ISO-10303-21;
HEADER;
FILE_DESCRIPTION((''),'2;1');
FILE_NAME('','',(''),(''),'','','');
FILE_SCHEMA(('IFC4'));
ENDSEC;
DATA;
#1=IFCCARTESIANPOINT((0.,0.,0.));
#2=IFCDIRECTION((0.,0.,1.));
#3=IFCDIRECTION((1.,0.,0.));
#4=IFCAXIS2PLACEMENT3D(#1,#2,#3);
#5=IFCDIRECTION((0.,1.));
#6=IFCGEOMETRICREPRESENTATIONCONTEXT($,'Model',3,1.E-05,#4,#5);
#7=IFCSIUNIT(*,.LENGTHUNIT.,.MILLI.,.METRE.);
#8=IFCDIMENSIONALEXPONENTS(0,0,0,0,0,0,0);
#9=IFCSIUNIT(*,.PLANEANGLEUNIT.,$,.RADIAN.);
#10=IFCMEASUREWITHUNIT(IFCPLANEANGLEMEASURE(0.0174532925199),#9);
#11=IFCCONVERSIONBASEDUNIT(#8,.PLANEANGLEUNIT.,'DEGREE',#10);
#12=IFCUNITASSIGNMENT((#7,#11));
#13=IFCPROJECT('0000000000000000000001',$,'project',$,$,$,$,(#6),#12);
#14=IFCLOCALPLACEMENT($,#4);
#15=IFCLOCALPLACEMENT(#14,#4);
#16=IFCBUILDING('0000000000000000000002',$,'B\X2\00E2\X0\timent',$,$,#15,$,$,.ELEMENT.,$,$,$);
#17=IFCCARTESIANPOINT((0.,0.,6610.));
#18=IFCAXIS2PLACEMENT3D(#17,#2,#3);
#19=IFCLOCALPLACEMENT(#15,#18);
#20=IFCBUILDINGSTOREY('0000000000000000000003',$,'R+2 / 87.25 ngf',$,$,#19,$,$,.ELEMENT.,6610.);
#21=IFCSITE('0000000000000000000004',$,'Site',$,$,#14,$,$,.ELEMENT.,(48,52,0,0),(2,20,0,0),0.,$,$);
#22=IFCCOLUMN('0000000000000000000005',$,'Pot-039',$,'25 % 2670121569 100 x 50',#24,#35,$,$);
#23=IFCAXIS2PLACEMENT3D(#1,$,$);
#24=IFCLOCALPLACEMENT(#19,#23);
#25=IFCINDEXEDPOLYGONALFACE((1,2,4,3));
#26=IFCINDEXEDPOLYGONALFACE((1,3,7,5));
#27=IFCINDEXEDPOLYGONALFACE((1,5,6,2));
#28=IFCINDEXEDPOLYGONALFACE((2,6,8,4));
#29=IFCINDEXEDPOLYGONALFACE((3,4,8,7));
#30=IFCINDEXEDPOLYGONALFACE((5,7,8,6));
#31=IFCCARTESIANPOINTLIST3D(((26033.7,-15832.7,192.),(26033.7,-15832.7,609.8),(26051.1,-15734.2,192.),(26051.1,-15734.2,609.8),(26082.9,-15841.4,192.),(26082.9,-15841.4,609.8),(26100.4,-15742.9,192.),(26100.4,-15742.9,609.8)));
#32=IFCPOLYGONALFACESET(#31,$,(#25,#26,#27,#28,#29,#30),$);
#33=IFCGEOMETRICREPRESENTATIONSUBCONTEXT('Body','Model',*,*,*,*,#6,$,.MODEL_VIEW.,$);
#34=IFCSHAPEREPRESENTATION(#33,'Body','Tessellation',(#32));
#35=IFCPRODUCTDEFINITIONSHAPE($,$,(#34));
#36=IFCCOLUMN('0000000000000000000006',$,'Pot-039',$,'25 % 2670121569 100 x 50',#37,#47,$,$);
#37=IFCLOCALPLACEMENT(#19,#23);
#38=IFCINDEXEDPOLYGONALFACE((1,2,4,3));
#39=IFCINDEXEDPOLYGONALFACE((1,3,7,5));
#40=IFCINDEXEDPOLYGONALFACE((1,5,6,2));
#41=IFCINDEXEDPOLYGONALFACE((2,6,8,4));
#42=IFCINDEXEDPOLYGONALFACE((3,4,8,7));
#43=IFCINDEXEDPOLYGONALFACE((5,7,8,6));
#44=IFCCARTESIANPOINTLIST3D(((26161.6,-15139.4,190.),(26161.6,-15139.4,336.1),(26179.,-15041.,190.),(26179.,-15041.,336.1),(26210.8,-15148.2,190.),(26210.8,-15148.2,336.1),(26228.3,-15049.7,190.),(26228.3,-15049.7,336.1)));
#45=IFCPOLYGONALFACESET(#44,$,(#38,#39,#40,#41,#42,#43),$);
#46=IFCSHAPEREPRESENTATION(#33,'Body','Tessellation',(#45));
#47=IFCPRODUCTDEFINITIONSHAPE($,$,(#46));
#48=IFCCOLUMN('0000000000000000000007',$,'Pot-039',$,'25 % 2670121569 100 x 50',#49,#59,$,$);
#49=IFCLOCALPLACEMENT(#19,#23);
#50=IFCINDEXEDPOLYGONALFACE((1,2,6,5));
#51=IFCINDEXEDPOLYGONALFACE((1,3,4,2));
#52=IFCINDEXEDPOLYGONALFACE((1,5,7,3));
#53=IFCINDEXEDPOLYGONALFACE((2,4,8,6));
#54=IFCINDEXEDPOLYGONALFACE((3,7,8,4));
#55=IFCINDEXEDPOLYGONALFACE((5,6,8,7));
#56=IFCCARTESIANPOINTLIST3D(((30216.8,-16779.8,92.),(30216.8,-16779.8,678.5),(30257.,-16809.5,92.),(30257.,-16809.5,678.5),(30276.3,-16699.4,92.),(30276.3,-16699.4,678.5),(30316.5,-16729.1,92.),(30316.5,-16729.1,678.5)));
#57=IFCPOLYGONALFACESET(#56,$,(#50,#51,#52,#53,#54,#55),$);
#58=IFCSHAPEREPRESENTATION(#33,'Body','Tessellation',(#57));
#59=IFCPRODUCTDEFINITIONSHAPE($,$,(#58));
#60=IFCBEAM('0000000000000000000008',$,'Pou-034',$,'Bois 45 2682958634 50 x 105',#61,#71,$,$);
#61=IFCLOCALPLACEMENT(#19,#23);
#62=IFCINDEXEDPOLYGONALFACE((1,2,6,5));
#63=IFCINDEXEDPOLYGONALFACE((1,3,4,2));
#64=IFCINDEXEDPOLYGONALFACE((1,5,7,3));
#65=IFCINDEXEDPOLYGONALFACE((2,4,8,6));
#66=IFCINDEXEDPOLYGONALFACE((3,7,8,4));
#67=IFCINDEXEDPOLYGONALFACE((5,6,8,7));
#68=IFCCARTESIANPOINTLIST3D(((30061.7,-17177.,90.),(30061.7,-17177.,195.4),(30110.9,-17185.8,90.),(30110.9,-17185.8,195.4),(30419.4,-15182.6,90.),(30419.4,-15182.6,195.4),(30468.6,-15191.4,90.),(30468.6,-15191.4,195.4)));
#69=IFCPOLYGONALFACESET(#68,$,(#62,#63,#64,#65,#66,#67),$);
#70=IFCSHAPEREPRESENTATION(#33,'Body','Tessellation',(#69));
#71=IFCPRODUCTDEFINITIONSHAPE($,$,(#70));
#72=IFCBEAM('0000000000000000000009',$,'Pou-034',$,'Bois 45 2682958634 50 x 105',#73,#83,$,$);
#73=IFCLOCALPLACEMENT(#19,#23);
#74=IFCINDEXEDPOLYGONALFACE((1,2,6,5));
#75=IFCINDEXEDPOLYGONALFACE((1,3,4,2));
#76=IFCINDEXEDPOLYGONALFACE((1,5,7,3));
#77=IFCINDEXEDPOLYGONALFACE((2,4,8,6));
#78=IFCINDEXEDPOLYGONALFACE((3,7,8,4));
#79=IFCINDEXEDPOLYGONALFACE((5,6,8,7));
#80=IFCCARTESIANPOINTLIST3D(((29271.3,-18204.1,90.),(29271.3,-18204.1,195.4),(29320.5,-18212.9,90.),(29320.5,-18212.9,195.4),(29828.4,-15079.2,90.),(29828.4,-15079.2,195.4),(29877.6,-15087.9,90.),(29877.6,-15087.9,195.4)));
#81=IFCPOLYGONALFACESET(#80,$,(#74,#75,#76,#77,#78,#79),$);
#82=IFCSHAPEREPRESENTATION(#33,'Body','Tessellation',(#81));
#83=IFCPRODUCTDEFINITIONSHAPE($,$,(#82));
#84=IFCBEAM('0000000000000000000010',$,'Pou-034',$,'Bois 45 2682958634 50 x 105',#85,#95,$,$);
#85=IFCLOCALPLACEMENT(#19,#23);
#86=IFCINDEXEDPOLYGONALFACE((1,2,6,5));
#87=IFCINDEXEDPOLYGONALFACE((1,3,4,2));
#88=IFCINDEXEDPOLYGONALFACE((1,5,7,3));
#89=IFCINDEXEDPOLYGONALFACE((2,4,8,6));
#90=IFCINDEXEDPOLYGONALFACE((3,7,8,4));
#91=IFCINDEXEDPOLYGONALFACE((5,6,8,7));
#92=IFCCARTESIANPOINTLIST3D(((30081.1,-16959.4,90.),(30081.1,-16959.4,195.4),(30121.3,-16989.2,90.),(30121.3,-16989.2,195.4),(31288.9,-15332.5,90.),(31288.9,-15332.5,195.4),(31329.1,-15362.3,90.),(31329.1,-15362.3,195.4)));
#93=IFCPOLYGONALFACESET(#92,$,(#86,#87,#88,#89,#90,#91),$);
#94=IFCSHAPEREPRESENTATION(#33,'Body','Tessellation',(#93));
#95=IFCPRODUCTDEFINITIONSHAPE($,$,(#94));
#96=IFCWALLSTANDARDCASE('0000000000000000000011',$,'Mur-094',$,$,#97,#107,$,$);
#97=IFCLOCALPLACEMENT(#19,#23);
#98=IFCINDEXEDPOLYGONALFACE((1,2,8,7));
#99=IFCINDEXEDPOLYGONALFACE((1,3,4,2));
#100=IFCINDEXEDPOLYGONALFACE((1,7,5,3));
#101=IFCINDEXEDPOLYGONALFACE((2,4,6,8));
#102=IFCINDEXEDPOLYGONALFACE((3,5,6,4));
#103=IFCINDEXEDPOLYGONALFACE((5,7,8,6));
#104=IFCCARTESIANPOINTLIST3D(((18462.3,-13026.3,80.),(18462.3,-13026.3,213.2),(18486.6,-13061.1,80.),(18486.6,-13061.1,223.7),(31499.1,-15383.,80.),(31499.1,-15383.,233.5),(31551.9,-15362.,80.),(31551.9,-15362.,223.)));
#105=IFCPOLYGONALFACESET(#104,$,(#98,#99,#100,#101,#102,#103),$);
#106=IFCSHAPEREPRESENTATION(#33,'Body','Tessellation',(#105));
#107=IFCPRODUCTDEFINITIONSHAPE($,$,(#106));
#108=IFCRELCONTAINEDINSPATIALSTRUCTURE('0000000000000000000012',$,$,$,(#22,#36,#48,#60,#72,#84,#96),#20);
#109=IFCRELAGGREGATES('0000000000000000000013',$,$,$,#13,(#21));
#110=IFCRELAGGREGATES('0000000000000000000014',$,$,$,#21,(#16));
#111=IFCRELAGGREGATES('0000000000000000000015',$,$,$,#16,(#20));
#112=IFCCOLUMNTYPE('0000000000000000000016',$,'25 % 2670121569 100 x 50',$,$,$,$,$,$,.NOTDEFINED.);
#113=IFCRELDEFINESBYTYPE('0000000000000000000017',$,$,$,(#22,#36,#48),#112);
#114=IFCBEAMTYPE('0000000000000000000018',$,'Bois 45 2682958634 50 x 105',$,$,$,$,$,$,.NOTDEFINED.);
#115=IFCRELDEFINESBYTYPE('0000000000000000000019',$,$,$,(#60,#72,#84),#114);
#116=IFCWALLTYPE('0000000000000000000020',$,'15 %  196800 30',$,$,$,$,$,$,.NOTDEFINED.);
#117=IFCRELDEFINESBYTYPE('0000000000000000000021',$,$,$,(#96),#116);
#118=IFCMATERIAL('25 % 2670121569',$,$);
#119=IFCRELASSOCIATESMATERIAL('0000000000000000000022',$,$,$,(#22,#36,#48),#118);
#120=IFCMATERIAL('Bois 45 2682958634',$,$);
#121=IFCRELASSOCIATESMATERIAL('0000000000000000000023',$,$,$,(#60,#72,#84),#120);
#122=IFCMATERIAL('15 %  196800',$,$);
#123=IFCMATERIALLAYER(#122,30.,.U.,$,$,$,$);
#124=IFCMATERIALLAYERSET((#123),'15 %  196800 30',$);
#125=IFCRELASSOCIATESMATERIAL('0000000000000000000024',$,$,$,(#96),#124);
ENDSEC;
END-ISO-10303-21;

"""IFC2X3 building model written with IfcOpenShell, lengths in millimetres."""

from ifc_helpers import new_model, entity, si_unit, converted_unit, direction, frame, frame_2d, origin_with_axes, origin_2d_with_axis, place, context, subcontext, project, spatial, polyline, rectangle, outline, extrude, clip, halfspace, material, layer, layer_set, layer_usage, type_object, element, save


model = new_model("IFC2X3")

# Units and contexts
model_context = context("Model", 3, precision=1e-05, world=origin_with_axes(), true_north=direction((0.0, 1.0)))
body_context = subcontext(model_context, "Body", "Model", "MODEL_VIEW")
ifc_project = project(units=[si_unit("LENGTHUNIT", "METRE", prefix="MILLI"), converted_unit("PLANEANGLEUNIT", "DEGREE", entity("IfcPlaneAngleMeasure", 0.0174532925199), si_unit("PLANEANGLEUNIT", "RADIAN"), dimensions=[0, 0, 0, 0, 0, 0, 0])], contexts=[model_context])

# Site, building, storey
site_placement = place(None, origin_with_axes())
site = spatial("IfcSite", under=ifc_project, at=site_placement, Name="Site", CompositionType="ELEMENT", RefLatitude=(48, 52, 0, 0), RefLongitude=(2, 20, 0, 0), RefElevation=0.0)
building_placement = place(site_placement, origin_with_axes())
building = spatial("IfcBuilding", under=site, at=building_placement, Name="Bâtiment", CompositionType="ELEMENT")
storey_placement = place(building_placement, frame((0.0, 0.0, 6610.0), z_axis=(0.0, 0.0, 1.0), x_axis=(1.0, 0.0, 0.0)))
storey = spatial("IfcBuildingStorey", under=building, at=storey_placement, Name="R+2 / 87.25 ngf", CompositionType="ELEMENT", Elevation=6610.0)

# Columns
ifc_material_1 = material(Name="25 % 2670121569")
column_type = type_object("IfcColumnType", Name="25 % 2670121569 100 x 50", PredefinedType="NOTDEFINED")
column_1_placement = place(storey_placement, frame((26067.0, -15787.8, 192.0), z_axis=(0.0, 0.0, 1.0), x_axis=(0.17478, 0.984607, 0.0)))
element("IfcColumn", 1, at=column_1_placement, inside=storey, type_object=column_type, material=ifc_material_1, Name="Pot-039", ObjectType="25 % 2670121569 100 x 50", context=body_context, shape_type="SweptSolid", body=[
    extrude(rectangle(XDim=100.0, YDim=50.0, at=origin_2d_with_axis()), origin_with_axes(), (0.0, 0.0, 1.0), 417.8),
])
column_2_placement = place(storey_placement, frame((26194.9, -15094.6, 190.0), z_axis=(0.0, 0.0, 1.0), x_axis=(0.174407, 0.984674, 0.0)))
element("IfcColumn", 2, at=column_2_placement, inside=storey, type_object=column_type, material=ifc_material_1, Name="Pot-039", ObjectType="25 % 2670121569 100 x 50", context=body_context, shape_type="SweptSolid", body=[
    extrude(rectangle(XDim=100.0, YDim=50.0, at=origin_2d_with_axis()), origin_with_axes(), (0.0, 0.0, 1.0), 146.1),
])
column_3_placement = place(storey_placement, frame((30266.6, -16754.5, 92.0), z_axis=(0.0, 0.0, 1.0), x_axis=(0.594664, 0.803974, 0.0)))
element("IfcColumn", 3, at=column_3_placement, inside=storey, type_object=column_type, material=ifc_material_1, Name="Pot-039", ObjectType="25 % 2670121569 100 x 50", context=body_context, shape_type="SweptSolid", body=[
    extrude(rectangle(XDim=100.0, YDim=50.0, at=origin_2d_with_axis()), origin_with_axes(), (0.0, 0.0, 1.0), 586.5),
])

# Beams
ifc_material_2 = material(Name="Bois 45 2682958634")
beam_type = type_object("IfcBeamType", Name="Bois 45 2682958634 50 x 105", PredefinedType="NOTDEFINED")
beam_1_placement = place(storey_placement, frame((30086.3, -17181.4, 195.4), z_axis=(0.0, 0.0, 1.0), x_axis=(0.984298, -0.176517, 0.0)))
element("IfcBeam", 4, at=beam_1_placement, inside=storey, type_object=beam_type, material=ifc_material_2, Name="Pou-034", ObjectType="Bois 45 2682958634 50 x 105", context=body_context, shape_type="SweptSolid", body=[
    extrude(rectangle(XDim=105.4, YDim=50.0, at=frame_2d((-52.7, 0.0), x_axis=(1.0, 0.0))), frame((0.0, 0.0, 0.0), z_axis=(0.0, 1.0, 0.0), x_axis=(0.0, 0.0, 1.0)), (0.0, 0.0, 1.0), 2026.3),
])
beam_2_placement = place(storey_placement, frame((29295.9, -18208.5, 195.4), z_axis=(0.0, 0.0, 1.0), x_axis=(0.984479, -0.175501, 0.0)))
element("IfcBeam", 5, at=beam_2_placement, inside=storey, type_object=beam_type, material=ifc_material_2, Name="Pou-034", ObjectType="Bois 45 2682958634 50 x 105", context=body_context, shape_type="SweptSolid", body=[
    extrude(rectangle(XDim=105.4, YDim=50.0, at=frame_2d((-52.7, 0.0), x_axis=(1.0, 0.0))), frame((0.0, 0.0, 0.0), z_axis=(0.0, 1.0, 0.0), x_axis=(0.0, 0.0, 1.0)), (0.0, 0.0, 1.0), 3174.2),
])
beam_3_placement = place(storey_placement, frame((30101.2, -16974.3, 195.4), z_axis=(0.0, 0.0, 1.0), x_axis=(0.802924, -0.596082, 0.0)))
element("IfcBeam", 6, at=beam_3_placement, inside=storey, type_object=beam_type, material=ifc_material_2, Name="Pou-034", ObjectType="Bois 45 2682958634 50 x 105", context=body_context, shape_type="SweptSolid", body=[
    extrude(rectangle(XDim=105.4, YDim=50.0, at=frame_2d((-52.7, 0.0), x_axis=(1.0, 0.0))), frame((0.0, 0.0, 0.0), z_axis=(0.0, 1.0, 0.0), x_axis=(0.0, 0.0, 1.0)), (0.0, 0.0, 1.0), 2026.3),
])

# Wall
ifc_material_3 = material(Name="15 %  196800")
ifc_layer = layer(ifc_material_3, 30.0, ventilated="UNKNOWN")
ifc_layer_set = layer_set([ifc_layer], Name="15 %  196800 30")
wall_type = type_object("IfcWallType", Name="15 %  196800 30", PredefinedType="NOTDEFINED")
ifc_layer_usage_1 = layer_usage(ifc_layer_set, "AXIS2", "NEGATIVE", 30.0)
wall_1_placement = place(storey_placement, frame((31551.9, -15362.0, 80.0), z_axis=(0.0, 0.0, 1.0), x_axis=(-0.984451, 0.175662, 0.0)))
element("IfcWallStandardCase", 7, at=wall_1_placement, inside=storey, type_object=wall_type, material=ifc_layer_usage_1, Name="Mur-094", context=body_context, shape_type="Clipping", body=[
    clip(extrude(outline(polyline([(0.0, 0.0), (13296.4, 0.0), (13266.3, 30.0), (48.3, 30.0), (0.0, 0.0)])), origin_with_axes(), (0.0, 0.0, 1.0), 590.0), halfspace(frame((0.1, -44.6, 127.4), z_axis=(-0.000693, 0.33035, -0.943858), x_axis=(0.0, 0.943859, 0.33035)), True)),
])

save(model, "model.ifc")
